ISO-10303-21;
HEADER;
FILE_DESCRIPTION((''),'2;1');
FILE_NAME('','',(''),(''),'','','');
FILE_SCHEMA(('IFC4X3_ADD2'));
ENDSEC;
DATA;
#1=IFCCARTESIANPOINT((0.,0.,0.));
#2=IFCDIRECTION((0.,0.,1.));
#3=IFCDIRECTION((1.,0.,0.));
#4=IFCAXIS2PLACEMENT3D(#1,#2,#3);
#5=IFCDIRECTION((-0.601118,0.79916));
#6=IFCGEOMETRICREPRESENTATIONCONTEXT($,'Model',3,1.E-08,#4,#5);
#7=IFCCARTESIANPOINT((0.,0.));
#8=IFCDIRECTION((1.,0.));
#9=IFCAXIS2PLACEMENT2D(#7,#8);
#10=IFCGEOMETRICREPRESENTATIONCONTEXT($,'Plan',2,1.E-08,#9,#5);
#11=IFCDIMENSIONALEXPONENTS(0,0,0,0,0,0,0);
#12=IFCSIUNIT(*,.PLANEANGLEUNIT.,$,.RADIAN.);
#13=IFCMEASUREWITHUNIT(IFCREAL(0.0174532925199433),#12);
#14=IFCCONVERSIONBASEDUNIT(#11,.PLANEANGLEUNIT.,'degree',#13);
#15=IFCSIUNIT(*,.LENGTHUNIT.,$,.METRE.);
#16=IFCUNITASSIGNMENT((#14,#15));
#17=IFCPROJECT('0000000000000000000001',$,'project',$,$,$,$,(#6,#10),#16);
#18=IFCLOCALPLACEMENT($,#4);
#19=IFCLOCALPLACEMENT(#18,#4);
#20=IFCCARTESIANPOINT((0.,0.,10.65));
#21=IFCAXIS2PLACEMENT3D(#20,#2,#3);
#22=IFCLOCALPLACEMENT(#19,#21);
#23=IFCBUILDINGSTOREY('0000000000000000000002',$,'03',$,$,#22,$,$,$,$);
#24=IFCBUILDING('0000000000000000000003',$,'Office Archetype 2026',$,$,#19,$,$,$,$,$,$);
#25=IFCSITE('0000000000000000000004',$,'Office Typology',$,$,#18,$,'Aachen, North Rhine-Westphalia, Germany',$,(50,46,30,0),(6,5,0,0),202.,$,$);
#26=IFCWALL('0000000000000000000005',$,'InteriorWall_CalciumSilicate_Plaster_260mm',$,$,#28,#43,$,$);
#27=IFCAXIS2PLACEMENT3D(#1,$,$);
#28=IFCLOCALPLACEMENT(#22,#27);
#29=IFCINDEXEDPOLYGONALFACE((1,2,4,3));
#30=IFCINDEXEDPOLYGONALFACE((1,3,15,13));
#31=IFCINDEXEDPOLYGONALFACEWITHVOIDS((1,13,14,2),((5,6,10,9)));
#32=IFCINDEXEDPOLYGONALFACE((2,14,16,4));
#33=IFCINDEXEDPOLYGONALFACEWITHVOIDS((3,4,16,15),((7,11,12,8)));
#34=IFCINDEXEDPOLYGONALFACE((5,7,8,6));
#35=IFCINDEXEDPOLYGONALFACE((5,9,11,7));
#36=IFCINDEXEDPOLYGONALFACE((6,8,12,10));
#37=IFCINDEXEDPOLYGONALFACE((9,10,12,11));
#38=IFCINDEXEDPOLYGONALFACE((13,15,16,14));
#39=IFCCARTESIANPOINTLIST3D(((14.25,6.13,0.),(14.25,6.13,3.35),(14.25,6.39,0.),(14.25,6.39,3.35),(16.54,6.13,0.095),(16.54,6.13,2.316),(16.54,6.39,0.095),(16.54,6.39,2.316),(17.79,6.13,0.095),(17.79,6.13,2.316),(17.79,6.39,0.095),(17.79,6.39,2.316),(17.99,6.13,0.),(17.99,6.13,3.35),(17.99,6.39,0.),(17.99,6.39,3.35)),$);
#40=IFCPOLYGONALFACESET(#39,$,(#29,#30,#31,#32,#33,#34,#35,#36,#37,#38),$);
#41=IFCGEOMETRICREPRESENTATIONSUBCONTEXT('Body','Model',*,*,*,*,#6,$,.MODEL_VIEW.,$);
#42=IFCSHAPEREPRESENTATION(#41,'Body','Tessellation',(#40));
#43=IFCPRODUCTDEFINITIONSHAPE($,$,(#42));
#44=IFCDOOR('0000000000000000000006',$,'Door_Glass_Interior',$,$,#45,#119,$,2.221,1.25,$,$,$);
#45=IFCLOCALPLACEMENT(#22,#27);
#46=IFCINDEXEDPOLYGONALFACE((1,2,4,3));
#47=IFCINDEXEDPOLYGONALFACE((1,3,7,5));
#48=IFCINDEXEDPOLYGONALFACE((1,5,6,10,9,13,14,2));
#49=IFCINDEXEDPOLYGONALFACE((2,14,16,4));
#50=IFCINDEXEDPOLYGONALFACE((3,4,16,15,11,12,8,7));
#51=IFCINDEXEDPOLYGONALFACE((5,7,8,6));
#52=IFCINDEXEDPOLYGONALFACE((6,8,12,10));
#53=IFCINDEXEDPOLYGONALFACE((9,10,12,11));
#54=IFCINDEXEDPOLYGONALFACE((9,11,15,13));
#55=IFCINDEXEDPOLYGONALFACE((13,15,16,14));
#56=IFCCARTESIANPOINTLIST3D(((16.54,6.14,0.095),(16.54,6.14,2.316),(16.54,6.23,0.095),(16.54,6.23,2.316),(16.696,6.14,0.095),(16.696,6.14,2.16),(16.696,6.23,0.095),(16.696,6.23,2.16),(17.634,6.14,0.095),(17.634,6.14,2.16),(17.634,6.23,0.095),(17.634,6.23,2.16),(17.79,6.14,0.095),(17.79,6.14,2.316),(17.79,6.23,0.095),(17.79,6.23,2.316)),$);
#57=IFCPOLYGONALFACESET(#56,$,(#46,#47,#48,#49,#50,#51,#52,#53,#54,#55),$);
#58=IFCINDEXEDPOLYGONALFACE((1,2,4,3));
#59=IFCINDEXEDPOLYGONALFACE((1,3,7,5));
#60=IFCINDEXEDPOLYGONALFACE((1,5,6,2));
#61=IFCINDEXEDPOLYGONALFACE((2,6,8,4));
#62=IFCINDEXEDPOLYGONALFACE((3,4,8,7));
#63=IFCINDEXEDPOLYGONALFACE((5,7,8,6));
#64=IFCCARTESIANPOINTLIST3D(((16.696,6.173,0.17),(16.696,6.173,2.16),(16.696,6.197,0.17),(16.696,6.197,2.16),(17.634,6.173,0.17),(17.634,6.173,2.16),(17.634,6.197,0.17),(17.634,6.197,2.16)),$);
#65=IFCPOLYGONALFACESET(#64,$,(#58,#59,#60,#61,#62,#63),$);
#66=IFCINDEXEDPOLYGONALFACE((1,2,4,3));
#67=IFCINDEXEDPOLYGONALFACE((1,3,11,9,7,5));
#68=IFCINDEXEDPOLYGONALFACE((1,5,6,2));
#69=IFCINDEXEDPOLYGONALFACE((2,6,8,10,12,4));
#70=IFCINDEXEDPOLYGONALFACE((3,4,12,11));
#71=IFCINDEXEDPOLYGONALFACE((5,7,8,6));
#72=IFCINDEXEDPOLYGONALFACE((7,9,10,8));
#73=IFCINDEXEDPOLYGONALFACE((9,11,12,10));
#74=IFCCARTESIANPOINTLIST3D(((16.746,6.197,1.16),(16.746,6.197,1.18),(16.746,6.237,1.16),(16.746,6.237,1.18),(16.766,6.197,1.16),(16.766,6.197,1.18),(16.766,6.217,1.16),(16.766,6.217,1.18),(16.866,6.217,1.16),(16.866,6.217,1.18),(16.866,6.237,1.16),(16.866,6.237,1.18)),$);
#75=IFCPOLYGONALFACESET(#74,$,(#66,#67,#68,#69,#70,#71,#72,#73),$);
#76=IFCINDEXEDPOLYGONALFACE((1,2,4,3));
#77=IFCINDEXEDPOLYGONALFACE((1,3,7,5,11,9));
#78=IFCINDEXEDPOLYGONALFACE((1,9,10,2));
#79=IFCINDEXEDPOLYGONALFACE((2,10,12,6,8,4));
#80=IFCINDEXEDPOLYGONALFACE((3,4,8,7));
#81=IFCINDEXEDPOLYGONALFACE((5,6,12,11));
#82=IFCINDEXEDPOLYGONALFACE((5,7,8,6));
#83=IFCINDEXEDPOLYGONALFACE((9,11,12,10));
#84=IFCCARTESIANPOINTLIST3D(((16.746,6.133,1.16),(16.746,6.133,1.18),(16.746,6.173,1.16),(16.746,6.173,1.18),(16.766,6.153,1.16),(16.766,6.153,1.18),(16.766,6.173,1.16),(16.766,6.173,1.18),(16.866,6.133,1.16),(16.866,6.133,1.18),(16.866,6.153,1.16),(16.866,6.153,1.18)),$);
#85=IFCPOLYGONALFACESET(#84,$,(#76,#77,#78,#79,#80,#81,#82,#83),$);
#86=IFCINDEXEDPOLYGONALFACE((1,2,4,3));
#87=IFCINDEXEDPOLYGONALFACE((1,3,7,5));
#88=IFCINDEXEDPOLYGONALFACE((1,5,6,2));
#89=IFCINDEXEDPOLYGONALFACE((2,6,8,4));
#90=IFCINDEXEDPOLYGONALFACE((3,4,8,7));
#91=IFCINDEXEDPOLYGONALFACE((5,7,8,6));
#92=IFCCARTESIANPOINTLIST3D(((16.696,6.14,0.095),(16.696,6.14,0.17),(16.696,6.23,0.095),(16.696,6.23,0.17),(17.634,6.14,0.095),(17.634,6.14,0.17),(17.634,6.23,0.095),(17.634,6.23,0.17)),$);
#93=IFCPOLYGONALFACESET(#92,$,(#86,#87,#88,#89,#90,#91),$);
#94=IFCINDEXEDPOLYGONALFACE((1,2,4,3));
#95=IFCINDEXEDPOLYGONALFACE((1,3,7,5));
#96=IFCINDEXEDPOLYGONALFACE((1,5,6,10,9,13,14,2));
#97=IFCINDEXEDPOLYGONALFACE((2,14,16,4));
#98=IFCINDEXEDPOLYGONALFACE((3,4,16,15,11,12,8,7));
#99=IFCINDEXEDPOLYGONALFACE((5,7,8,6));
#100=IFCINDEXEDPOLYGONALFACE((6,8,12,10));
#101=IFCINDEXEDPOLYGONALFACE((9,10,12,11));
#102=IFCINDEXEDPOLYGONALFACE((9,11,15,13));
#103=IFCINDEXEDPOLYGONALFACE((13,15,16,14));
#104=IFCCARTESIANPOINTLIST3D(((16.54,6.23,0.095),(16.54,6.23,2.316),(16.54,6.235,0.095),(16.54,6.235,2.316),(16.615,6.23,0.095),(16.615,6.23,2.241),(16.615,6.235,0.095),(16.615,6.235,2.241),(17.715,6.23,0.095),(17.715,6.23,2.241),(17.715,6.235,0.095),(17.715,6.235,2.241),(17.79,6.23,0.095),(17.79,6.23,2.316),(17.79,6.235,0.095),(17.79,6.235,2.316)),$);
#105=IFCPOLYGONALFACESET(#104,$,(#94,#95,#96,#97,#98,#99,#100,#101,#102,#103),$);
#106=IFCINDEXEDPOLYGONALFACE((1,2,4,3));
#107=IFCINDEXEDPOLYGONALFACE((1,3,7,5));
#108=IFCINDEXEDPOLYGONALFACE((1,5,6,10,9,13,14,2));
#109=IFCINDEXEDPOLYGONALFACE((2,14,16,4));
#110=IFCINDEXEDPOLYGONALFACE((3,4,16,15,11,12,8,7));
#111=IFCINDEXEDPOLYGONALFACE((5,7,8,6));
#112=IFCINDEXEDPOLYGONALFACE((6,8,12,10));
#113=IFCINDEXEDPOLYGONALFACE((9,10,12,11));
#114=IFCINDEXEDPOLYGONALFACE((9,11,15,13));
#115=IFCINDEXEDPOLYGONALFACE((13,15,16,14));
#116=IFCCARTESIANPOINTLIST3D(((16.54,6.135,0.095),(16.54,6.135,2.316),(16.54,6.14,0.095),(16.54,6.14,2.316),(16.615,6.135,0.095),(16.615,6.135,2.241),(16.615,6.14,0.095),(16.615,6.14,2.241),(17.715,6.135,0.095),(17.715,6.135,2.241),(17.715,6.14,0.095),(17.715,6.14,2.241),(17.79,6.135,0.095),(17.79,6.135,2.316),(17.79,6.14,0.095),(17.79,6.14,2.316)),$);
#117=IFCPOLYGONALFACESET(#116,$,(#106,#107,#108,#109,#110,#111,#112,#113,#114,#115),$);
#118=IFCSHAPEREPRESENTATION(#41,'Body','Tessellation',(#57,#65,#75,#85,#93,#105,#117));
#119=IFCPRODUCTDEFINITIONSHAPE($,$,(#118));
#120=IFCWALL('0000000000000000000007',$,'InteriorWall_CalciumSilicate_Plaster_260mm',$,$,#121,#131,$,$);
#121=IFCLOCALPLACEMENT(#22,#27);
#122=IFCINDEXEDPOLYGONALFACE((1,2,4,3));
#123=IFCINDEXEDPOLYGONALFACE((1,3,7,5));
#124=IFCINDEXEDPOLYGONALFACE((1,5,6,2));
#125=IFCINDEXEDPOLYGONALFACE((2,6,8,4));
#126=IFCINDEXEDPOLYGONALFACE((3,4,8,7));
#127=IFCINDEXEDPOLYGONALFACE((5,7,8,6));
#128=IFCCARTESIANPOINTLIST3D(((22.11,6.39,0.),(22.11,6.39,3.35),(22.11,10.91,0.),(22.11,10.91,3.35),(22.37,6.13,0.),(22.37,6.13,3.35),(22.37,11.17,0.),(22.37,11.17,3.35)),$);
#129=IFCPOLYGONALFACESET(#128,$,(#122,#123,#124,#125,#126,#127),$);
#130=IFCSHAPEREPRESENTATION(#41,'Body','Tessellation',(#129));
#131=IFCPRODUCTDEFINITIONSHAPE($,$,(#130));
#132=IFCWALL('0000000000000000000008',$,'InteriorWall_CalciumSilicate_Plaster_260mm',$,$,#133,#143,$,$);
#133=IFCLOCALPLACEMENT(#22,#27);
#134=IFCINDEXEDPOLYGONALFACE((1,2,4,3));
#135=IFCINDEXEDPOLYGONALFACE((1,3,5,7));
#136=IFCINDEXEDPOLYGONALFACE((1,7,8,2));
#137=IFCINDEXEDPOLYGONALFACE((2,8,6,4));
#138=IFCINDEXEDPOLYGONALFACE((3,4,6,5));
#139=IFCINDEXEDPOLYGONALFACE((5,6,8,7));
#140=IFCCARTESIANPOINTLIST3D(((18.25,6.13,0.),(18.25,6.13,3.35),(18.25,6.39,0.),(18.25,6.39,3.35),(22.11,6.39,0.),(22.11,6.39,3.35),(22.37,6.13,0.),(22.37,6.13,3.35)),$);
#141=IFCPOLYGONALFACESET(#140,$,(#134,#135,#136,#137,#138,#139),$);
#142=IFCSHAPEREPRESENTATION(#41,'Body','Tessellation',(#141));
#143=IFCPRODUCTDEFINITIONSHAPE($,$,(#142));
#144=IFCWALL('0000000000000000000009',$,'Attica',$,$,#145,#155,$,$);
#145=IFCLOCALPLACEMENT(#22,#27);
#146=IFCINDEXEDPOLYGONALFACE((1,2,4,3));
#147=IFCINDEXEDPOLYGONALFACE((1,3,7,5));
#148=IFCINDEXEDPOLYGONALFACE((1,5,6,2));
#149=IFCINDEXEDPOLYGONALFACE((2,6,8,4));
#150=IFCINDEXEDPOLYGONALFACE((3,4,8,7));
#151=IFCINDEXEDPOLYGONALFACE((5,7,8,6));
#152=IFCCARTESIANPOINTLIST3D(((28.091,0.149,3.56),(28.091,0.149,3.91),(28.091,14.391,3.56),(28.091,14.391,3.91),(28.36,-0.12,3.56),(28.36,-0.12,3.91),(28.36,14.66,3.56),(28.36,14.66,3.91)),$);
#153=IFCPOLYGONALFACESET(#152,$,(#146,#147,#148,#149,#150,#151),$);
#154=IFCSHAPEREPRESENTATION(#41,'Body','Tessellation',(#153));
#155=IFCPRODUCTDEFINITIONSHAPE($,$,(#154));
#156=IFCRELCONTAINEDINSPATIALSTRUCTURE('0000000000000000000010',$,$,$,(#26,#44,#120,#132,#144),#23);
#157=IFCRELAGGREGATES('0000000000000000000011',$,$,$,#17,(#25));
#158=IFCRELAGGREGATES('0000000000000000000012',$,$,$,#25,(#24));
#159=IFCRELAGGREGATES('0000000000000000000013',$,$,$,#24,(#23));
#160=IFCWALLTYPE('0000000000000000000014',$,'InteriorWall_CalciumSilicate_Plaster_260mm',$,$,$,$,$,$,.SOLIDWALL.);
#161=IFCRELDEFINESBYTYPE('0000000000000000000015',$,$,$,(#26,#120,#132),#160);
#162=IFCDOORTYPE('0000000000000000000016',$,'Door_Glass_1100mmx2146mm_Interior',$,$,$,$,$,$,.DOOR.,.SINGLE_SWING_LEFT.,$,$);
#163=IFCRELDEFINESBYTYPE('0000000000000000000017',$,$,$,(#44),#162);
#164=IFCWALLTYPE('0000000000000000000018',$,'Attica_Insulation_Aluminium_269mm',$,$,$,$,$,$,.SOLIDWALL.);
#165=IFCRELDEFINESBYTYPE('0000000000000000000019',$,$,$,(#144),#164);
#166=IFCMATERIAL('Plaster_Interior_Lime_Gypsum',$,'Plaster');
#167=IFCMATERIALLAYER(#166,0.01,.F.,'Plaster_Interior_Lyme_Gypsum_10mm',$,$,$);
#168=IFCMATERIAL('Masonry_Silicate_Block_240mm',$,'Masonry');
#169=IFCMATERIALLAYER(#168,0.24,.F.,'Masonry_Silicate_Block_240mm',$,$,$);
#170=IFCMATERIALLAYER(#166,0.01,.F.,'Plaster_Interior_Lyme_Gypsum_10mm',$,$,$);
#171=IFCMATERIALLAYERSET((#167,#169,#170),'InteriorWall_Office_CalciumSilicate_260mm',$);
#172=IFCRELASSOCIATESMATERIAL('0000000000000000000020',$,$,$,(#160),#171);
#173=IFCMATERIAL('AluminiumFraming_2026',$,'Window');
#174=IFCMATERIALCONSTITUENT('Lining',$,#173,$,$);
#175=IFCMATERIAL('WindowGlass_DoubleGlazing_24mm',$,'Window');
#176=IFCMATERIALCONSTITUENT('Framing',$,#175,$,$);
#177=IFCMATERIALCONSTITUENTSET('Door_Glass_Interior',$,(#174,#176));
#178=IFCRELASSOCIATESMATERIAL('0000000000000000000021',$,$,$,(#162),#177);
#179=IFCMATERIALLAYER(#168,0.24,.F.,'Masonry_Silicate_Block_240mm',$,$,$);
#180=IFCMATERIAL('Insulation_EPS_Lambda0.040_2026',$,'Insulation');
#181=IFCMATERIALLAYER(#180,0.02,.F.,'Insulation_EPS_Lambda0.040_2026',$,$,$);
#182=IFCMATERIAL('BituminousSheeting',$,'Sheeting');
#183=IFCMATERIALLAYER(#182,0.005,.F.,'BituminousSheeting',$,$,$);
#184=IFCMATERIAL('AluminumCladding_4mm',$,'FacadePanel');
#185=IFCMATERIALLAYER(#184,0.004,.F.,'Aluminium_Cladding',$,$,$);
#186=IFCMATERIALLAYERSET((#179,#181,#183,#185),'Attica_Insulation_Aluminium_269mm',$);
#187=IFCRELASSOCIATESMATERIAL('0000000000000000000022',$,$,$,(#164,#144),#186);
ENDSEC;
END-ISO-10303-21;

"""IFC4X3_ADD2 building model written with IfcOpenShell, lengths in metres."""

from ifc_helpers import new_model, entity, si_unit, converted_unit, direction, frame, origin_with_axes, origin_2d_with_axis, place, context, subcontext, project, spatial, line, indexed_curve, outline, extrude, source, transform, mapped, material, layer, layer_set, layer_usage, constituent, constituent_set, type_object, type_shapes, element, fill, save


model = new_model("IFC4X3_ADD2")

# Units and contexts
model_context = context("Model", 3, precision=1e-08, world=origin_with_axes(), true_north=direction((-0.601118, 0.79916)))
plan_context = context("Plan", 2, precision=1e-08, world=origin_2d_with_axis(), true_north=direction((-0.601118, 0.79916)))
body_context = subcontext(model_context, "Body", "Model", "MODEL_VIEW")
ifc_project = project(units=[converted_unit("PLANEANGLEUNIT", "degree", entity("IfcReal", 0.0174532925199433), si_unit("PLANEANGLEUNIT", "RADIAN"), dimensions=[0, 0, 0, 0, 0, 0, 0]), si_unit("LENGTHUNIT", "METRE")], contexts=[model_context, plan_context])

# Site, building, storey
site_placement = place(None, origin_with_axes())
site = spatial("IfcSite", under=ifc_project, at=site_placement, Name="Office Typology", LongName="Aachen, North Rhine-Westphalia, Germany", RefLatitude=(50, 46, 30, 0), RefLongitude=(6, 5, 0, 0), RefElevation=202.0)
building_placement = place(site_placement, origin_with_axes())
building = spatial("IfcBuilding", under=site, at=building_placement, Name="Office Archetype 2026")
storey_placement = place(building_placement, frame((0.0, 0.0, 10.65), z_axis=(0.0, 0.0, 1.0), x_axis=(1.0, 0.0, 0.0)))
storey = spatial("IfcBuildingStorey", under=building, at=storey_placement, Name="03")

# Wall, opening, door
ifc_material_1 = material(Name="Plaster_Interior_Lime_Gypsum", Category="Plaster")
ifc_layer_1 = layer(ifc_material_1, 0.01, ventilated=False, Name="Plaster_Interior_Lyme_Gypsum_10mm")
ifc_material_2 = material(Name="Masonry_Silicate_Block_240mm", Category="Masonry")
ifc_layer_2 = layer(ifc_material_2, 0.24, ventilated=False, Name="Masonry_Silicate_Block_240mm")
ifc_layer_3 = layer(ifc_material_1, 0.01, ventilated=False, Name="Plaster_Interior_Lyme_Gypsum_10mm")
ifc_layer_set_1 = layer_set([ifc_layer_1, ifc_layer_2, ifc_layer_3], Name="InteriorWall_Office_CalciumSilicate_260mm")
wall_type_1 = type_object("IfcWallType", Name="InteriorWall_CalciumSilicate_Plaster_260mm", PredefinedType="SOLIDWALL", material=ifc_layer_set_1)
wall_1_placement = place(storey_placement, frame((18.25, 6.39, 0.0), z_axis=(0.0, 0.0, 1.0), x_axis=(-1.0, 0.0, 0.0)))
wall_1 = element("IfcWall", 1, at=wall_1_placement, inside=storey, type_object=wall_type_1, Name="InteriorWall_CalciumSilicate_Plaster_260mm", context=body_context, shape_type="SweptSolid", body=[
    extrude(outline(indexed_curve([(0.26, 0.0), (0.26, 0.26), (4.0, 0.26), (4.0, 0.0), (0.26, 0.0)])), origin_with_axes(), (0.0, 0.0, 1.0), 3.35),
])
shared_shape_1 = source(origin_with_axes(), body_context, "Body", "SweptSolid", [
    extrude(outline(indexed_curve([(0.0, 2.221), (1.25, 2.221), (1.25, 0.0), (0.0, 0.0), (0.0, 2.221)])), frame((0.0, -0.16, 0.0), z_axis=(0.0, -1.0, 0.0), x_axis=(1.0, 0.0, 0.0)), (0.0, 0.0, -1.0), 0.26),
])
opening_1_placement = place(wall_1_placement, frame((0.46, 0.16, 0.095), z_axis=(0.0, 0.0, 1.0), x_axis=(1.0, 0.0, 0.0)))
opening_1 = element("IfcOpeningElement", 2, at=opening_1_placement, cuts=wall_1, PredefinedType="OPENING", context=body_context, shape_type="MappedRepresentation", body=[
    mapped(shared_shape_1, transform((0.0, 0.0, 0.0), x_axis=(1.0, 0.0, 0.0), y_axis=(0.0, 1.0, 0.0), z_axis=(0.0, 0.0, 1.0), scale=1.0)),
])
ifc_material_3 = material(Name="AluminiumFraming_2026", Category="Window")
ifc_constituent_1 = constituent(ifc_material_3, Name="Lining")
ifc_material_4 = material(Name="WindowGlass_DoubleGlazing_24mm", Category="Window")
ifc_constituent_2 = constituent(ifc_material_4, Name="Framing")
ifc_constituent_set_1 = constituent_set(constituents=[ifc_constituent_1, ifc_constituent_2], Name="Door_Glass_Interior")
door_type = type_object("IfcDoorType", Name="Door_Glass_1100mmx2146mm_Interior", OperationType="SINGLE_SWING_LEFT", PredefinedType="DOOR", material=ifc_constituent_set_1)
shared_shape_2 = source(origin_with_axes(), body_context, "Body", "SweptSolid", [
    extrude(outline(indexed_curve([(0.0, 0.0), (0.0, 2.221), (1.25, 2.221), (1.25, 0.0), (1.094, 0.0), (1.094, 2.065), (0.156, 2.065), (0.156, 0.0)], segments=[line(1, 2, 3, 4, 5, 6, 7, 8, 1)])), frame((0.0, 0.0, 0.0), z_axis=(0.0, -1.0, 0.0), x_axis=(1.0, 0.0, 0.0)), (0.0, 0.0, -1.0), 0.09),
    extrude(outline(indexed_curve([(0.0, 0.0), (0.938, 0.0), (0.938, 0.024), (0.0, 0.024)], segments=[line(1, 2, 3, 4, 1)])), frame((0.156, 0.033, 0.075), z_axis=(0.0, 0.0, 1.0), x_axis=(1.0, 0.0, 0.0)), (0.0, 0.0, 1.0), 1.99),
    extrude(outline(indexed_curve([(0.0, 0.0), (0.0, -0.04), (-0.12, -0.04), (-0.12, -0.02), (-0.02, -0.02), (-0.02, 0.0)], segments=[line(1, 2, 3, 4, 5, 6, 1)])), frame((1.044, 0.033, 1.065), z_axis=(0.0, 0.0, 1.0), x_axis=(1.0, 0.0, 0.0)), (0.0, 0.0, 1.0), 0.02),
    extrude(outline(indexed_curve([(0.0, 0.0), (0.0, 0.04), (-0.12, 0.04), (-0.12, 0.02), (-0.02, 0.02), (-0.02, 0.0)], segments=[line(1, 2, 3, 4, 5, 6, 1)])), frame((1.044, 0.057, 1.065), z_axis=(0.0, 0.0, 1.0), x_axis=(1.0, 0.0, 0.0)), (0.0, 0.0, 1.0), 0.02),
    extrude(outline(indexed_curve([(0.0, 0.0), (0.938, 0.0), (0.938, 0.09), (0.0, 0.09)], segments=[line(1, 2, 3, 4, 1)])), frame((0.156, 0.0, 0.0), z_axis=(0.0, 0.0, 1.0), x_axis=(1.0, 0.0, 0.0)), (0.0, 0.0, 1.0), 0.075),
    extrude(outline(indexed_curve([(0.0, 0.0), (0.0, 2.221), (1.25, 2.221), (1.25, 0.0), (1.175, 0.0), (1.175, 2.146), (0.075, 2.146), (0.075, 0.0)], segments=[line(1, 2, 3, 4, 5, 6, 7, 8, 1)])), frame((0.0, -0.005, 0.0), z_axis=(0.0, -1.0, 0.0), x_axis=(1.0, 0.0, 0.0)), (0.0, 0.0, -1.0), 0.005),
    extrude(outline(indexed_curve([(0.0, 0.0), (0.0, 2.221), (1.25, 2.221), (1.25, 0.0), (1.175, 0.0), (1.175, 2.146), (0.075, 2.146), (0.075, 0.0)], segments=[line(1, 2, 3, 4, 5, 6, 7, 8, 1)])), frame((0.0, 0.09, 0.0), z_axis=(0.0, -1.0, 0.0), x_axis=(1.0, 0.0, 0.0)), (0.0, 0.0, -1.0), 0.005),
])
type_shapes(door_type, [shared_shape_2])
door_placement = place(opening_1_placement, origin_with_axes())
door = element("IfcDoor", 3, at=door_placement, inside=storey, type_object=door_type, Name="Door_Glass_Interior", OverallHeight=2.221, OverallWidth=1.25, context=body_context, shape_type="MappedRepresentation", body=[
    mapped(shared_shape_2, transform((0.0, 0.0, 0.0), x_axis=(1.0, 0.0, 0.0), y_axis=(0.0, 1.0, 0.0), z_axis=(0.0, 0.0, 1.0), scale=1.0)),
])
fill(opening_1, door)

# Walls
wall_2_placement = place(storey_placement, frame((22.37, 6.13, 0.0), z_axis=(0.0, 0.0, 1.0), x_axis=(0.0, 1.0, 0.0)))
element("IfcWall", 4, at=wall_2_placement, inside=storey, type_object=wall_type_1, Name="InteriorWall_CalciumSilicate_Plaster_260mm", context=body_context, shape_type="SweptSolid", body=[
    extrude(outline(indexed_curve([(0.0, 0.0), (0.26, 0.26), (4.78, 0.26), (5.04, 0.0)], segments=[line(1, 2, 3, 4, 1)])), origin_with_axes(), (0.0, 0.0, 1.0), 3.35),
])
wall_3_placement = place(storey_placement, frame((18.25, 6.13, 0.0), z_axis=(0.0, 0.0, 1.0), x_axis=(1.0, 0.0, 0.0)))
element("IfcWall", 5, at=wall_3_placement, inside=storey, type_object=wall_type_1, Name="InteriorWall_CalciumSilicate_Plaster_260mm", context=body_context, shape_type="SweptSolid", body=[
    extrude(outline(indexed_curve([(0.0, 0.0), (0.0, 0.26), (3.86, 0.26), (4.12, 0.0)], segments=[line(1, 2, 3, 4, 1)])), origin_with_axes(), (0.0, 0.0, 1.0), 3.35),
])

# Wall
ifc_layer_4 = layer(ifc_material_2, 0.24, ventilated=False, Name="Masonry_Silicate_Block_240mm")
ifc_material_5 = material(Name="Insulation_EPS_Lambda0.040_2026", Category="Insulation")
ifc_layer_5 = layer(ifc_material_5, 0.02, ventilated=False, Name="Insulation_EPS_Lambda0.040_2026")
ifc_material_6 = material(Name="BituminousSheeting", Category="Sheeting")
ifc_layer_6 = layer(ifc_material_6, 0.005, ventilated=False, Name="BituminousSheeting")
ifc_material_7 = material(Name="AluminumCladding_4mm", Category="FacadePanel")
ifc_layer_7 = layer(ifc_material_7, 0.004, ventilated=False, Name="Aluminium_Cladding")
ifc_layer_set_2 = layer_set([ifc_layer_4, ifc_layer_5, ifc_layer_6, ifc_layer_7], Name="Attica_Insulation_Aluminium_269mm")
ifc_layer_usage_1 = layer_usage(ifc_layer_set_2, "AXIS2", "POSITIVE", 0.0)
wall_type_2 = type_object("IfcWallType", Name="Attica_Insulation_Aluminium_269mm", PredefinedType="SOLIDWALL", material=ifc_layer_set_2)
wall_4_placement = place(storey_placement, frame((28.36, -0.12, 3.56), z_axis=(0.0, 0.0, 1.0), x_axis=(0.0, 1.0, 0.0)))
element("IfcWall", 6, at=wall_4_placement, inside=storey, type_object=wall_type_2, material=ifc_layer_usage_1, Name="Attica", context=body_context, shape_type="SweptSolid", body=[
    extrude(outline(indexed_curve([(0.0, 0.0), (0.269, 0.269), (14.511, 0.269), (14.78, 0.0)], segments=[line(1, 2, 3, 4, 1)])), origin_with_axes(), (0.0, 0.0, 1.0), 0.35),
])

save(model, "model.ifc")
